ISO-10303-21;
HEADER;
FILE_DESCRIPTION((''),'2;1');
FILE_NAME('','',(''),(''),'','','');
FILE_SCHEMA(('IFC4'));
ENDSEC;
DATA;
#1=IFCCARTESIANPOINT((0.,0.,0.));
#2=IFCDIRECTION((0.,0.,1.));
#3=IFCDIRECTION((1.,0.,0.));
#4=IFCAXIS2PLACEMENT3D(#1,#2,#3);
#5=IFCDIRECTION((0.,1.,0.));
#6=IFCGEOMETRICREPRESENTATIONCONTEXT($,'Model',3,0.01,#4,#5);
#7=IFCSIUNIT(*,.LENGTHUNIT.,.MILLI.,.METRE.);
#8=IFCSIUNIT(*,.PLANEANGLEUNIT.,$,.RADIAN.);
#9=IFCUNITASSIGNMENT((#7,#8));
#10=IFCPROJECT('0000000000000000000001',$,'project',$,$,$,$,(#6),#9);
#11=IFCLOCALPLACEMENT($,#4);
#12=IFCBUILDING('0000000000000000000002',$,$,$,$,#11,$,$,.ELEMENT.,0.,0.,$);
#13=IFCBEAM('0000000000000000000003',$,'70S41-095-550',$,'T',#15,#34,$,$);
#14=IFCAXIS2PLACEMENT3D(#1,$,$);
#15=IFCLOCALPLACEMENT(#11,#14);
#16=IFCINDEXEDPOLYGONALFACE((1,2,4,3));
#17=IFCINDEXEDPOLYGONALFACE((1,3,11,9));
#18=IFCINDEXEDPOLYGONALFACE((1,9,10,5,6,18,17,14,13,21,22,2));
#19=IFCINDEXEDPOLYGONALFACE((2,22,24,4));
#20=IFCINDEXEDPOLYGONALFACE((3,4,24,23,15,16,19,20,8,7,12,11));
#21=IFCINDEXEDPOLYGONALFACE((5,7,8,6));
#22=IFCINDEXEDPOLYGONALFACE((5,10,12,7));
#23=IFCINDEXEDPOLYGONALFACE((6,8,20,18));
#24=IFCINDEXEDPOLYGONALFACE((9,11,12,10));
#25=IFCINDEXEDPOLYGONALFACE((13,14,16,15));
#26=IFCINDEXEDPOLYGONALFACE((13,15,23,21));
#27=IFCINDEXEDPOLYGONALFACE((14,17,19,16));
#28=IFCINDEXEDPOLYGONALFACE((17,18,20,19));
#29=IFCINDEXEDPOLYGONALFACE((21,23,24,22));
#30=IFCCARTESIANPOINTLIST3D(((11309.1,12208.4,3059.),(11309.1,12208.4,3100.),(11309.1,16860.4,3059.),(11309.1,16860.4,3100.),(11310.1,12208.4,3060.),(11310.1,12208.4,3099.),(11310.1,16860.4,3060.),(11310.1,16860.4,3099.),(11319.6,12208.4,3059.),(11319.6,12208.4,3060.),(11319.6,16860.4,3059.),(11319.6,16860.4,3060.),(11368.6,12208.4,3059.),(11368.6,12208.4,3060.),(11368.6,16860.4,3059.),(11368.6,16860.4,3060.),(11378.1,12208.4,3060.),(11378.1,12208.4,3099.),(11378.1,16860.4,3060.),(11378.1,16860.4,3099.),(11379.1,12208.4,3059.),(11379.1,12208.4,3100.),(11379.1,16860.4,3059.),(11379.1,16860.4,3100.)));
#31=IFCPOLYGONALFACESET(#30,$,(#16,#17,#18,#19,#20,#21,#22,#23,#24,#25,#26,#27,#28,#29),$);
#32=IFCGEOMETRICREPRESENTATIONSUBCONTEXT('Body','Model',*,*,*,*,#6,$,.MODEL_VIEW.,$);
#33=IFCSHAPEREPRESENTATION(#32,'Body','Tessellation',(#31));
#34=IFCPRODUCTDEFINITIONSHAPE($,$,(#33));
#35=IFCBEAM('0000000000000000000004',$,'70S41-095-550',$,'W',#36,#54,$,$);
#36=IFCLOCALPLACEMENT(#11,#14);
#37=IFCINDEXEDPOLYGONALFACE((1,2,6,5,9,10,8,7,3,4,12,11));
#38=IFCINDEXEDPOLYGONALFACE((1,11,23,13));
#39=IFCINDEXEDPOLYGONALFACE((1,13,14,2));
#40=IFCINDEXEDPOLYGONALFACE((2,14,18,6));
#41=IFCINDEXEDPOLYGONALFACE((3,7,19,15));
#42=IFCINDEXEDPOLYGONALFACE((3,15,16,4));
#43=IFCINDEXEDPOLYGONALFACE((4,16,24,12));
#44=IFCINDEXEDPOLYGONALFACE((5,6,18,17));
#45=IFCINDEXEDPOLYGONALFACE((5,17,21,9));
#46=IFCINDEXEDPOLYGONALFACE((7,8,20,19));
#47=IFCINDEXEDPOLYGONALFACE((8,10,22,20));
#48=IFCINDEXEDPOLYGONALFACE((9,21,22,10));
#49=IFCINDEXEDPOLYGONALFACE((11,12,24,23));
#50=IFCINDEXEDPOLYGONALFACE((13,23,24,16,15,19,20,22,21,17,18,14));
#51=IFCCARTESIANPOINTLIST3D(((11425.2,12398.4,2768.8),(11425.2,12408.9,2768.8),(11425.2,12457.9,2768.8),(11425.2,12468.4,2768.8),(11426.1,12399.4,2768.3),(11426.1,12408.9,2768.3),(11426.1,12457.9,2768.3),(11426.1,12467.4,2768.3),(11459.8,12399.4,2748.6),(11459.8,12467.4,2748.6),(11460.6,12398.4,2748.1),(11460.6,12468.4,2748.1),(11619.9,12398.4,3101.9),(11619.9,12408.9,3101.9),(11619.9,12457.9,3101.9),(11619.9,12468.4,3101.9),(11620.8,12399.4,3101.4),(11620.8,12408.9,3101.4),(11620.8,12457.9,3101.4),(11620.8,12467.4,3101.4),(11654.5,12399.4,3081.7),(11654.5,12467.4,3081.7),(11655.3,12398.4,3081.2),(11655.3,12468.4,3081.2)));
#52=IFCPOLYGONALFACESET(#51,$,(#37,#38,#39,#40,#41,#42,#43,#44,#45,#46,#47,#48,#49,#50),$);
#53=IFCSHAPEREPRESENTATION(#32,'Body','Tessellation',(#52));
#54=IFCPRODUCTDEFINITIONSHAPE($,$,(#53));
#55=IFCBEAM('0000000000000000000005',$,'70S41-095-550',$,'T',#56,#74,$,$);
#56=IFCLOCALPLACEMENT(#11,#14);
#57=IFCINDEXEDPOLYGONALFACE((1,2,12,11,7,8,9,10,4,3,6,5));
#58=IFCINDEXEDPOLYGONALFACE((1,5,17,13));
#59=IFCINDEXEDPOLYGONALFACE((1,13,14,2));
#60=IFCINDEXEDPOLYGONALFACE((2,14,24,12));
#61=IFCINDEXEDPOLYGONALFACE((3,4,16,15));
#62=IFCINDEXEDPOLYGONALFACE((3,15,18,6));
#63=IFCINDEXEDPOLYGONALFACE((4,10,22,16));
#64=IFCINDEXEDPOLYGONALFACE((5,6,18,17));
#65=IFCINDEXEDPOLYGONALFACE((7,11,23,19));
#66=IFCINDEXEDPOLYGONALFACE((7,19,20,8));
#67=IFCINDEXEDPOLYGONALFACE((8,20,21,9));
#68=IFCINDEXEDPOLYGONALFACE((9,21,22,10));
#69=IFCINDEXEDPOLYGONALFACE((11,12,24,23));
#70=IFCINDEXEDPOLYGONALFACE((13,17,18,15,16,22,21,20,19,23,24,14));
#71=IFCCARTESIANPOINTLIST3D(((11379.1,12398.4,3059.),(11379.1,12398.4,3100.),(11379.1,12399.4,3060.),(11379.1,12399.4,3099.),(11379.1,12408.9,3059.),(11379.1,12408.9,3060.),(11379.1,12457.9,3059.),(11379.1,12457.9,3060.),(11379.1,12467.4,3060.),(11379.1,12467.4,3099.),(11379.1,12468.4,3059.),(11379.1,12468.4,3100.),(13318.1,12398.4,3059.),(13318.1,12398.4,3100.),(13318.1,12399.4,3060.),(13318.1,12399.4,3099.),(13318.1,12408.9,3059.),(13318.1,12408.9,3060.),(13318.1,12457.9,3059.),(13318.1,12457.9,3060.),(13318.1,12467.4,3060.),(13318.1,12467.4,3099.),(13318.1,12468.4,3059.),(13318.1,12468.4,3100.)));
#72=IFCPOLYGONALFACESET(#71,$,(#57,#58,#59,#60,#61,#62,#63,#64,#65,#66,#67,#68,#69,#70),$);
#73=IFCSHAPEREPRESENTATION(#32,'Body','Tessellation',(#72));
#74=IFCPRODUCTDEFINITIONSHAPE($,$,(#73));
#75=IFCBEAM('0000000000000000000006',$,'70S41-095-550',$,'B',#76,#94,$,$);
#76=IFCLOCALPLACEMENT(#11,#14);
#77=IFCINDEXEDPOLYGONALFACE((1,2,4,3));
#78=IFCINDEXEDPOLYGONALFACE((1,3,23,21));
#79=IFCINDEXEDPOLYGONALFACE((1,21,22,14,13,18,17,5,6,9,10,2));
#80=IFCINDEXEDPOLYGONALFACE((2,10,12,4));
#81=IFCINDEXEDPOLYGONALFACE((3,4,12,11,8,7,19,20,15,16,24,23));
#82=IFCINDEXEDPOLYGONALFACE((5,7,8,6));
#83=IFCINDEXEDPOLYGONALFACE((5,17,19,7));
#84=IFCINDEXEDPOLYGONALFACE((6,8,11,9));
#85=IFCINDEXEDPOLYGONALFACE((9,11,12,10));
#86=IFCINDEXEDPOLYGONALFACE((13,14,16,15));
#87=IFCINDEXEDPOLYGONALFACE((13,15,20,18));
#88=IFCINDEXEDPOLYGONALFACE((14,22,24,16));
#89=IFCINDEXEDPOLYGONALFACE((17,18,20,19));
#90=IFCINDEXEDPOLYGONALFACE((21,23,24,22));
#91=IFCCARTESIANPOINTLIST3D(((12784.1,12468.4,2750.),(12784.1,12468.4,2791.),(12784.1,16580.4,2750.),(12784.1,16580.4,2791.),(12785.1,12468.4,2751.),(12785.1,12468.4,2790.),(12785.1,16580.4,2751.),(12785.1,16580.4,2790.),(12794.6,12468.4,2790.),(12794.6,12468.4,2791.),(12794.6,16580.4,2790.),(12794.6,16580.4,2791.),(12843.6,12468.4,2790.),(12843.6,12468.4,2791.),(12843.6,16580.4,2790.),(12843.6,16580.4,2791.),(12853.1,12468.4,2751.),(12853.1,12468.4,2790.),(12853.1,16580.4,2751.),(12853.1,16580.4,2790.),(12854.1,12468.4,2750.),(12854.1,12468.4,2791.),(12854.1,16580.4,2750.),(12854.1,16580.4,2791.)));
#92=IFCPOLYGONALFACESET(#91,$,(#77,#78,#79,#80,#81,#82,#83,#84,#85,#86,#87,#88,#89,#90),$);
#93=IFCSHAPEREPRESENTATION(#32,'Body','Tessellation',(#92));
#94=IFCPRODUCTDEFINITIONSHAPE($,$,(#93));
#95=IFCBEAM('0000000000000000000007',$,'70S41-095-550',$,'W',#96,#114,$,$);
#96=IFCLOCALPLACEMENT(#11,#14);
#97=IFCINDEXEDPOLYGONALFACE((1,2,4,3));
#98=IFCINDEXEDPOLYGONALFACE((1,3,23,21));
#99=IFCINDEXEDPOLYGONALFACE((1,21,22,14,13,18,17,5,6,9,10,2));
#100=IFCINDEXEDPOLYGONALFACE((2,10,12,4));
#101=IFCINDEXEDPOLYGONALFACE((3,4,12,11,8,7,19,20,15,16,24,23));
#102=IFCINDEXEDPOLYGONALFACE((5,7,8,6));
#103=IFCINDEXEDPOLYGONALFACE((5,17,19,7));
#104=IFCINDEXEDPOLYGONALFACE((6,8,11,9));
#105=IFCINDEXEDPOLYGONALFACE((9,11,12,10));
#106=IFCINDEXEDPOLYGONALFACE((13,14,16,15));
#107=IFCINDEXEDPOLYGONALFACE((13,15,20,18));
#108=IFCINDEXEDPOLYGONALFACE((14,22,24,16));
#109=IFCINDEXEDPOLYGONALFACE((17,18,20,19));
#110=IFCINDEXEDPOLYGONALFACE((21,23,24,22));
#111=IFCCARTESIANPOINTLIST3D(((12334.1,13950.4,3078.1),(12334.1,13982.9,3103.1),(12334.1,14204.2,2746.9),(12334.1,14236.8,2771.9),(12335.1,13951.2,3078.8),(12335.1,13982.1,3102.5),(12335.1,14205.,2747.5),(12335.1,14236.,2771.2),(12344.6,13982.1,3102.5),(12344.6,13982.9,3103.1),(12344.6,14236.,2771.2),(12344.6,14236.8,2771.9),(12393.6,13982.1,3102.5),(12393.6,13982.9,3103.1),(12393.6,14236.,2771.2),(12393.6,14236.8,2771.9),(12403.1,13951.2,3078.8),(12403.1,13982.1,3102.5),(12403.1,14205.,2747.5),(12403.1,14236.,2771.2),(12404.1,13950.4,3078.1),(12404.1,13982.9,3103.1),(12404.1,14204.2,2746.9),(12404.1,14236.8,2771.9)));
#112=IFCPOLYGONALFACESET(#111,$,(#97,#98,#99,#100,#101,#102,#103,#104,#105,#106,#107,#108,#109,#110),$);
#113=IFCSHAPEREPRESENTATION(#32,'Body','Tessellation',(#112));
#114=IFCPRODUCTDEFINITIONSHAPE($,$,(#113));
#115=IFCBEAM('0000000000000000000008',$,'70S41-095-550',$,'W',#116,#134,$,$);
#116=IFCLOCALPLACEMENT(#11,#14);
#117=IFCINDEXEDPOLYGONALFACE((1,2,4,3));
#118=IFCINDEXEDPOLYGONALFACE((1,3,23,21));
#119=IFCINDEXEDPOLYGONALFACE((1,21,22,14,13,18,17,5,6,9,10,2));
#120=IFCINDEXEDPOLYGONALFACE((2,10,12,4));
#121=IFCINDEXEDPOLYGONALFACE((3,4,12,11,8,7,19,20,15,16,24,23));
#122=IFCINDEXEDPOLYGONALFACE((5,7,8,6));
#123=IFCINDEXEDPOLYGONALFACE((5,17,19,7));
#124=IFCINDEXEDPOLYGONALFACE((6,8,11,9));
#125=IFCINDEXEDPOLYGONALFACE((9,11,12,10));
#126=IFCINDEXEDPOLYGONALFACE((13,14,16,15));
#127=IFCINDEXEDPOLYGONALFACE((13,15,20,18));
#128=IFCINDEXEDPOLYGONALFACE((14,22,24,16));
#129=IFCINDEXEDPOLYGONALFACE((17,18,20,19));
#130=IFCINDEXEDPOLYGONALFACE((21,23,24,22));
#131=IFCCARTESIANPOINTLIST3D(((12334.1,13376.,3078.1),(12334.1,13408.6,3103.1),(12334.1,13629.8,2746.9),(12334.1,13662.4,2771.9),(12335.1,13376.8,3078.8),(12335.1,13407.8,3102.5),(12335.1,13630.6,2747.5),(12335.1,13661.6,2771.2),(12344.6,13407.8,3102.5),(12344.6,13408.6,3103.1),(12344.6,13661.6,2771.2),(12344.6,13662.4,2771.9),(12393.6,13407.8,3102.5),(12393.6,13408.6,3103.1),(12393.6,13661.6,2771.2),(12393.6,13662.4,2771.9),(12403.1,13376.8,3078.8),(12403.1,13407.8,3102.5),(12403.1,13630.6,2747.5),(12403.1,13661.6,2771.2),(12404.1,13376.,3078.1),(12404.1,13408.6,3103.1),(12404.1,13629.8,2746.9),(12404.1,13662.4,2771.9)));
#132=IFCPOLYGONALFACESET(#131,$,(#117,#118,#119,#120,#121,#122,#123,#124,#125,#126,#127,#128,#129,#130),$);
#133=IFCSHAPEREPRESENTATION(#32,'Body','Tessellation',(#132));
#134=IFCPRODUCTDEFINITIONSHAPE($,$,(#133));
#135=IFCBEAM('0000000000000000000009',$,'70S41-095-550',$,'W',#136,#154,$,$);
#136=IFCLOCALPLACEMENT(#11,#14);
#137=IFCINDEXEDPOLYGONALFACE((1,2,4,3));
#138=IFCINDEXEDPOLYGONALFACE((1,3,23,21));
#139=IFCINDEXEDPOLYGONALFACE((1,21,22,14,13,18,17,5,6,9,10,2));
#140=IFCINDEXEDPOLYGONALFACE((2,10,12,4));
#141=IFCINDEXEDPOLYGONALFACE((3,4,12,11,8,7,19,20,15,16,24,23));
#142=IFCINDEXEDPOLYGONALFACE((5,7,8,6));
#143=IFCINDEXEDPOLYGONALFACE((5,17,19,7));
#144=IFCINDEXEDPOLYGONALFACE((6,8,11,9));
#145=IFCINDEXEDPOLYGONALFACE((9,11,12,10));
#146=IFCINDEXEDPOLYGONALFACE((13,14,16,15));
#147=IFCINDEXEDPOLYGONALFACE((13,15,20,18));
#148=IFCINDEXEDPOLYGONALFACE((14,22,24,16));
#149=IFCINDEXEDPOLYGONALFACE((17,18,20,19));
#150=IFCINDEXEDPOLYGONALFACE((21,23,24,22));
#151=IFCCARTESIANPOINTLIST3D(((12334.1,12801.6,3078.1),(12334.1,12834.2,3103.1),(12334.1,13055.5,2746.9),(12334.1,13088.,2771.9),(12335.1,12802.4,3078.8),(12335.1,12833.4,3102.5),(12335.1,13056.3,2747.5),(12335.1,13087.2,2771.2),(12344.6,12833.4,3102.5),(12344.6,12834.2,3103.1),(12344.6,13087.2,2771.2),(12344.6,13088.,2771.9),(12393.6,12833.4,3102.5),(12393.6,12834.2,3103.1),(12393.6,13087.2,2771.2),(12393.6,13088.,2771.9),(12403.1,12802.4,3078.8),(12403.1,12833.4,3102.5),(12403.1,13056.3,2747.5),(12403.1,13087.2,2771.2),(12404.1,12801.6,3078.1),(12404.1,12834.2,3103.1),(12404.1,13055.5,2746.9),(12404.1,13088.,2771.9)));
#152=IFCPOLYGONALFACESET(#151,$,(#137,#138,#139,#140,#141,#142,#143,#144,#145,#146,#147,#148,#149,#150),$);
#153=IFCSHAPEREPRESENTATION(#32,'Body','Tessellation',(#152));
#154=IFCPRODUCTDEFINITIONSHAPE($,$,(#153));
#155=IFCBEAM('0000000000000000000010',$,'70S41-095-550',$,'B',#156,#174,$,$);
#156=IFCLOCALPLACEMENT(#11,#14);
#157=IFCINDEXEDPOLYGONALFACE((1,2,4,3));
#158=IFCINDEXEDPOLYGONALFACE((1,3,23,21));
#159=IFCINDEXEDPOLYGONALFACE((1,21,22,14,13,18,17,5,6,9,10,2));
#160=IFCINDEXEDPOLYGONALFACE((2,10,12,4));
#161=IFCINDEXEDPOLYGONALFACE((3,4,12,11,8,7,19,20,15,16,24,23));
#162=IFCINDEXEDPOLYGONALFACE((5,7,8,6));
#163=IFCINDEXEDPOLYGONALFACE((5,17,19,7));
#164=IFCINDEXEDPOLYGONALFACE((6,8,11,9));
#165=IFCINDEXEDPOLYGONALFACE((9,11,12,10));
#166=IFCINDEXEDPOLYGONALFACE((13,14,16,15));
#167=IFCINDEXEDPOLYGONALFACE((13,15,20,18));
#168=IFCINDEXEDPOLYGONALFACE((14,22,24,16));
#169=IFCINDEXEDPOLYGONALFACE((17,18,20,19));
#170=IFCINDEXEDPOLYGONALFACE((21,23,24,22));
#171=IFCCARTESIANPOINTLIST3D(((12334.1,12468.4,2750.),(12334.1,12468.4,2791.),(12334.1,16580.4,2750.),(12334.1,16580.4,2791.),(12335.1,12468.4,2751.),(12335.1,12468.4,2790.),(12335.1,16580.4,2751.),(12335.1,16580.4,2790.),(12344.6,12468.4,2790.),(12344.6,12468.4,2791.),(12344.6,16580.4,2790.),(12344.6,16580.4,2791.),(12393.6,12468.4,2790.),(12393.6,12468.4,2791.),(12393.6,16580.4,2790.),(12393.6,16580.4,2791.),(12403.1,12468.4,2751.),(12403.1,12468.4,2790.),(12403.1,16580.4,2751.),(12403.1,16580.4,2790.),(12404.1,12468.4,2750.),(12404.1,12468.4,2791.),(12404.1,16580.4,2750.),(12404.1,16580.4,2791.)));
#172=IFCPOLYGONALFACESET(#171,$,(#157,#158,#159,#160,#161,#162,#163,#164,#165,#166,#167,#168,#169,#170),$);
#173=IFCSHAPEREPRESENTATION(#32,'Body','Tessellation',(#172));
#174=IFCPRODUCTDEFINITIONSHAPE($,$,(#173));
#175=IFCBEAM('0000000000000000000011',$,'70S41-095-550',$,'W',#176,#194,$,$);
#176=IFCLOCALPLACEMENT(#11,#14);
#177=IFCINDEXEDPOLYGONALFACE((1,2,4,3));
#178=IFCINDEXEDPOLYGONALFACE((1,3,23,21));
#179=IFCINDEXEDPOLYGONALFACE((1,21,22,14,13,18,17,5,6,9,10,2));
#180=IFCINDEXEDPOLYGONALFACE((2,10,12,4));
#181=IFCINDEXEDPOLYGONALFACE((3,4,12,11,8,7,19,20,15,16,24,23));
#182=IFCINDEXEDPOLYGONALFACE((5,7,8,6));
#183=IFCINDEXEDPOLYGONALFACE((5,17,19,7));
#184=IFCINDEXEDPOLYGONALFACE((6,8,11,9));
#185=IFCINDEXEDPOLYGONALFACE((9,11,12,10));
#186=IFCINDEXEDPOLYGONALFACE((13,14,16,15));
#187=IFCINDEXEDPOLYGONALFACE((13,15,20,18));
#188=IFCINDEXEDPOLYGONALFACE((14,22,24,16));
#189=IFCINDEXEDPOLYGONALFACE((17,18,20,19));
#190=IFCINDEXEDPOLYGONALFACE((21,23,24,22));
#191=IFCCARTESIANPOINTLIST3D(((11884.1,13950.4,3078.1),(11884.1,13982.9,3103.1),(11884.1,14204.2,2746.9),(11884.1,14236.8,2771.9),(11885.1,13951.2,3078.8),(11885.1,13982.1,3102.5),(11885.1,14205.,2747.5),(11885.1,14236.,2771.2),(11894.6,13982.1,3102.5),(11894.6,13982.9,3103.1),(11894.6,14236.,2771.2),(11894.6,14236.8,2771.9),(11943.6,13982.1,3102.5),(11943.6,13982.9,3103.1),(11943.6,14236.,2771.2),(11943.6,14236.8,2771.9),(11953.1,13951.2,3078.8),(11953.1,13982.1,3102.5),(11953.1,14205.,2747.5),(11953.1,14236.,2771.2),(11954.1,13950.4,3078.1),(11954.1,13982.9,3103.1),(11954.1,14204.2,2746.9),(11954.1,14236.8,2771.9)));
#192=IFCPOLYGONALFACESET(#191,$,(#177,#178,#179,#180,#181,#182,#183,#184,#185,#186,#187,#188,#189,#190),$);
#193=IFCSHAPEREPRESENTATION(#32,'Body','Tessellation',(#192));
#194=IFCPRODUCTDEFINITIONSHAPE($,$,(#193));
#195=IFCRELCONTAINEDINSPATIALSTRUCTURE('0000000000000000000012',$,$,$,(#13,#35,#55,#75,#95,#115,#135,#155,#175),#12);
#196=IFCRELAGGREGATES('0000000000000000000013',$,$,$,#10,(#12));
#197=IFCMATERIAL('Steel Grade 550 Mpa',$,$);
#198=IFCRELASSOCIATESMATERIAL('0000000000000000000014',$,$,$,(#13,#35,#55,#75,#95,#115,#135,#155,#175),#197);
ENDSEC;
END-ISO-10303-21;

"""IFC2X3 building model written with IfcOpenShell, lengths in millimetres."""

from ifc_helpers import new_model, si_unit, direction, frame, origin, origin_with_axes, origin_2d_with_axis, place, context, subcontext, project, spatial, c_section, extrude, source, transform, mapped, material, element, save


model = new_model("IFC2X3")

# Units and contexts
model_context = context("Model", 3, precision=0.01, world=origin_with_axes(), true_north=direction((0.0, 1.0, 0.0)))
body_context = subcontext(model_context, "Body", "Model", "MODEL_VIEW")
ifc_project = project(units=[si_unit("LENGTHUNIT", "METRE", prefix="MILLI"), si_unit("PLANEANGLEUNIT", "RADIAN")], contexts=[model_context])

# Building
building_placement = place(None, origin_with_axes())
building = spatial("IfcBuilding", under=ifc_project, at=building_placement, CompositionType="ELEMENT", ElevationOfRefHeight=0.0, ElevationOfTerrain=0.0)

# Shared definitions
ifc_material = material(Name="Steel Grade 550 Mpa")

# Beams
shared_shape_1 = source(origin(), body_context, "Body", "SweptSolid", [
    extrude(c_section(Depth=70.0, Width=41.0, WallThickness=1.0, Girth=10.5, at=origin_2d_with_axis()), origin_with_axes(), (0.0, 0.0, 1.0), 4652.0),
])
beam_1_placement = place(None, frame((11344.1, 12208.4, 3079.5), z_axis=(0.0, 1.0, 0.0), x_axis=(0.0, 0.0, -1.0)))
element("IfcBeam", 1, at=beam_1_placement, inside=building, material=ifc_material, Name="70S41-095-550", ObjectType="T", context=body_context, shape_type="MappedRepresentation", body=[
    mapped(shared_shape_1, transform((0.0, 0.0, 0.0), scale=1.0)),
])
shared_shape_2 = source(origin(), body_context, "Body", "SweptSolid", [
    extrude(c_section(Depth=70.0, Width=41.0, WallThickness=1.0, Girth=10.5, at=origin_2d_with_axis()), origin_with_axes(), (0.0, 0.0, 1.0), 385.9),
])
beam_2_placement = place(None, frame((11637.6, 12433.4, 3091.6), z_axis=(-0.504522, 0.0, -0.863399), x_axis=(-0.863399, 0.0, 0.504522)))
element("IfcBeam", 2, at=beam_2_placement, inside=building, material=ifc_material, Name="70S41-095-550", ObjectType="W", context=body_context, shape_type="MappedRepresentation", body=[
    mapped(shared_shape_2, transform((0.0, 0.0, 0.0), scale=1.0)),
])
shared_shape_3 = source(origin(), body_context, "Body", "SweptSolid", [
    extrude(c_section(Depth=70.0, Width=41.0, WallThickness=1.0, Girth=10.5, at=origin_2d_with_axis()), origin_with_axes(), (0.0, 0.0, 1.0), 1939.0),
])
beam_3_placement = place(None, frame((11379.1, 12433.4, 3079.5), z_axis=(1.0, 0.0, 0.0), x_axis=(0.0, 0.0, -1.0)))
element("IfcBeam", 3, at=beam_3_placement, inside=building, material=ifc_material, Name="70S41-095-550", ObjectType="T", context=body_context, shape_type="MappedRepresentation", body=[
    mapped(shared_shape_3, transform((0.0, 0.0, 0.0), scale=1.0)),
])
shared_shape_4 = source(origin(), body_context, "Body", "SweptSolid", [
    extrude(c_section(Depth=70.0, Width=41.0, WallThickness=1.0, Girth=10.5, at=origin_2d_with_axis()), origin_with_axes(), (0.0, 0.0, 1.0), 4112.0),
])
beam_4_placement = place(None, frame((12819.1, 12468.4, 2770.5), z_axis=(0.0, 1.0, 0.0), x_axis=(0.0, 0.0, 1.0)))
element("IfcBeam", 4, at=beam_4_placement, inside=building, material=ifc_material, Name="70S41-095-550", ObjectType="B", context=body_context, shape_type="MappedRepresentation", body=[
    mapped(shared_shape_4, transform((0.0, 0.0, 0.0), scale=1.0)),
])
shared_shape_5 = source(origin(), body_context, "Body", "SweptSolid", [
    extrude(c_section(Depth=70.0, Width=41.0, WallThickness=1.0, Girth=10.5, at=origin_2d_with_axis()), origin_with_axes(), (0.0, 0.0, 1.0), 417.3),
])
beam_5_placement = place(None, frame((12369.1, 13966.7, 3090.6), z_axis=(0.0, 0.608266, -0.793733), x_axis=(0.0, 0.793733, 0.608266)))
element("IfcBeam", 5, at=beam_5_placement, inside=building, material=ifc_material, Name="70S41-095-550", ObjectType="W", context=body_context, shape_type="MappedRepresentation", body=[
    mapped(shared_shape_5, transform((0.0, 0.0, 0.0), scale=1.0)),
])
shared_shape_6 = source(origin(), body_context, "Body", "SweptSolid", [
    extrude(c_section(Depth=70.0, Width=41.0, WallThickness=1.0, Girth=10.5, at=origin_2d_with_axis()), origin_with_axes(), (0.0, 0.0, 1.0), 417.3),
])
beam_6_placement = place(None, frame((12369.1, 13392.3, 3090.6), z_axis=(0.0, 0.608266, -0.793733), x_axis=(0.0, 0.793733, 0.608266)))
element("IfcBeam", 6, at=beam_6_placement, inside=building, material=ifc_material, Name="70S41-095-550", ObjectType="W", context=body_context, shape_type="MappedRepresentation", body=[
    mapped(shared_shape_6, transform((0.0, 0.0, 0.0), scale=1.0)),
])
shared_shape_7 = source(origin(), body_context, "Body", "SweptSolid", [
    extrude(c_section(Depth=70.0, Width=41.0, WallThickness=1.0, Girth=10.5, at=origin_2d_with_axis()), origin_with_axes(), (0.0, 0.0, 1.0), 417.3),
])
beam_7_placement = place(None, frame((12369.1, 12817.9, 3090.6), z_axis=(0.0, 0.608266, -0.793733), x_axis=(0.0, 0.793733, 0.608266)))
element("IfcBeam", 7, at=beam_7_placement, inside=building, material=ifc_material, Name="70S41-095-550", ObjectType="W", context=body_context, shape_type="MappedRepresentation", body=[
    mapped(shared_shape_7, transform((0.0, 0.0, 0.0), scale=1.0)),
])
shared_shape_8 = source(origin(), body_context, "Body", "SweptSolid", [
    extrude(c_section(Depth=70.0, Width=41.0, WallThickness=1.0, Girth=10.5, at=origin_2d_with_axis()), origin_with_axes(), (0.0, 0.0, 1.0), 4112.0),
])
beam_8_placement = place(None, frame((12369.1, 12468.4, 2770.5), z_axis=(0.0, 1.0, 0.0), x_axis=(0.0, 0.0, 1.0)))
element("IfcBeam", 8, at=beam_8_placement, inside=building, material=ifc_material, Name="70S41-095-550", ObjectType="B", context=body_context, shape_type="MappedRepresentation", body=[
    mapped(shared_shape_8, transform((0.0, 0.0, 0.0), scale=1.0)),
])
shared_shape_9 = source(origin(), body_context, "Body", "SweptSolid", [
    extrude(c_section(Depth=70.0, Width=41.0, WallThickness=1.0, Girth=10.5, at=origin_2d_with_axis()), origin_with_axes(), (0.0, 0.0, 1.0), 417.3),
])
beam_9_placement = place(None, frame((11919.1, 13966.7, 3090.6), z_axis=(0.0, 0.608266, -0.793733), x_axis=(0.0, 0.793733, 0.608266)))
element("IfcBeam", 9, at=beam_9_placement, inside=building, material=ifc_material, Name="70S41-095-550", ObjectType="W", context=body_context, shape_type="MappedRepresentation", body=[
    mapped(shared_shape_9, transform((0.0, 0.0, 0.0), scale=1.0)),
])

save(model, "model.ifc")
